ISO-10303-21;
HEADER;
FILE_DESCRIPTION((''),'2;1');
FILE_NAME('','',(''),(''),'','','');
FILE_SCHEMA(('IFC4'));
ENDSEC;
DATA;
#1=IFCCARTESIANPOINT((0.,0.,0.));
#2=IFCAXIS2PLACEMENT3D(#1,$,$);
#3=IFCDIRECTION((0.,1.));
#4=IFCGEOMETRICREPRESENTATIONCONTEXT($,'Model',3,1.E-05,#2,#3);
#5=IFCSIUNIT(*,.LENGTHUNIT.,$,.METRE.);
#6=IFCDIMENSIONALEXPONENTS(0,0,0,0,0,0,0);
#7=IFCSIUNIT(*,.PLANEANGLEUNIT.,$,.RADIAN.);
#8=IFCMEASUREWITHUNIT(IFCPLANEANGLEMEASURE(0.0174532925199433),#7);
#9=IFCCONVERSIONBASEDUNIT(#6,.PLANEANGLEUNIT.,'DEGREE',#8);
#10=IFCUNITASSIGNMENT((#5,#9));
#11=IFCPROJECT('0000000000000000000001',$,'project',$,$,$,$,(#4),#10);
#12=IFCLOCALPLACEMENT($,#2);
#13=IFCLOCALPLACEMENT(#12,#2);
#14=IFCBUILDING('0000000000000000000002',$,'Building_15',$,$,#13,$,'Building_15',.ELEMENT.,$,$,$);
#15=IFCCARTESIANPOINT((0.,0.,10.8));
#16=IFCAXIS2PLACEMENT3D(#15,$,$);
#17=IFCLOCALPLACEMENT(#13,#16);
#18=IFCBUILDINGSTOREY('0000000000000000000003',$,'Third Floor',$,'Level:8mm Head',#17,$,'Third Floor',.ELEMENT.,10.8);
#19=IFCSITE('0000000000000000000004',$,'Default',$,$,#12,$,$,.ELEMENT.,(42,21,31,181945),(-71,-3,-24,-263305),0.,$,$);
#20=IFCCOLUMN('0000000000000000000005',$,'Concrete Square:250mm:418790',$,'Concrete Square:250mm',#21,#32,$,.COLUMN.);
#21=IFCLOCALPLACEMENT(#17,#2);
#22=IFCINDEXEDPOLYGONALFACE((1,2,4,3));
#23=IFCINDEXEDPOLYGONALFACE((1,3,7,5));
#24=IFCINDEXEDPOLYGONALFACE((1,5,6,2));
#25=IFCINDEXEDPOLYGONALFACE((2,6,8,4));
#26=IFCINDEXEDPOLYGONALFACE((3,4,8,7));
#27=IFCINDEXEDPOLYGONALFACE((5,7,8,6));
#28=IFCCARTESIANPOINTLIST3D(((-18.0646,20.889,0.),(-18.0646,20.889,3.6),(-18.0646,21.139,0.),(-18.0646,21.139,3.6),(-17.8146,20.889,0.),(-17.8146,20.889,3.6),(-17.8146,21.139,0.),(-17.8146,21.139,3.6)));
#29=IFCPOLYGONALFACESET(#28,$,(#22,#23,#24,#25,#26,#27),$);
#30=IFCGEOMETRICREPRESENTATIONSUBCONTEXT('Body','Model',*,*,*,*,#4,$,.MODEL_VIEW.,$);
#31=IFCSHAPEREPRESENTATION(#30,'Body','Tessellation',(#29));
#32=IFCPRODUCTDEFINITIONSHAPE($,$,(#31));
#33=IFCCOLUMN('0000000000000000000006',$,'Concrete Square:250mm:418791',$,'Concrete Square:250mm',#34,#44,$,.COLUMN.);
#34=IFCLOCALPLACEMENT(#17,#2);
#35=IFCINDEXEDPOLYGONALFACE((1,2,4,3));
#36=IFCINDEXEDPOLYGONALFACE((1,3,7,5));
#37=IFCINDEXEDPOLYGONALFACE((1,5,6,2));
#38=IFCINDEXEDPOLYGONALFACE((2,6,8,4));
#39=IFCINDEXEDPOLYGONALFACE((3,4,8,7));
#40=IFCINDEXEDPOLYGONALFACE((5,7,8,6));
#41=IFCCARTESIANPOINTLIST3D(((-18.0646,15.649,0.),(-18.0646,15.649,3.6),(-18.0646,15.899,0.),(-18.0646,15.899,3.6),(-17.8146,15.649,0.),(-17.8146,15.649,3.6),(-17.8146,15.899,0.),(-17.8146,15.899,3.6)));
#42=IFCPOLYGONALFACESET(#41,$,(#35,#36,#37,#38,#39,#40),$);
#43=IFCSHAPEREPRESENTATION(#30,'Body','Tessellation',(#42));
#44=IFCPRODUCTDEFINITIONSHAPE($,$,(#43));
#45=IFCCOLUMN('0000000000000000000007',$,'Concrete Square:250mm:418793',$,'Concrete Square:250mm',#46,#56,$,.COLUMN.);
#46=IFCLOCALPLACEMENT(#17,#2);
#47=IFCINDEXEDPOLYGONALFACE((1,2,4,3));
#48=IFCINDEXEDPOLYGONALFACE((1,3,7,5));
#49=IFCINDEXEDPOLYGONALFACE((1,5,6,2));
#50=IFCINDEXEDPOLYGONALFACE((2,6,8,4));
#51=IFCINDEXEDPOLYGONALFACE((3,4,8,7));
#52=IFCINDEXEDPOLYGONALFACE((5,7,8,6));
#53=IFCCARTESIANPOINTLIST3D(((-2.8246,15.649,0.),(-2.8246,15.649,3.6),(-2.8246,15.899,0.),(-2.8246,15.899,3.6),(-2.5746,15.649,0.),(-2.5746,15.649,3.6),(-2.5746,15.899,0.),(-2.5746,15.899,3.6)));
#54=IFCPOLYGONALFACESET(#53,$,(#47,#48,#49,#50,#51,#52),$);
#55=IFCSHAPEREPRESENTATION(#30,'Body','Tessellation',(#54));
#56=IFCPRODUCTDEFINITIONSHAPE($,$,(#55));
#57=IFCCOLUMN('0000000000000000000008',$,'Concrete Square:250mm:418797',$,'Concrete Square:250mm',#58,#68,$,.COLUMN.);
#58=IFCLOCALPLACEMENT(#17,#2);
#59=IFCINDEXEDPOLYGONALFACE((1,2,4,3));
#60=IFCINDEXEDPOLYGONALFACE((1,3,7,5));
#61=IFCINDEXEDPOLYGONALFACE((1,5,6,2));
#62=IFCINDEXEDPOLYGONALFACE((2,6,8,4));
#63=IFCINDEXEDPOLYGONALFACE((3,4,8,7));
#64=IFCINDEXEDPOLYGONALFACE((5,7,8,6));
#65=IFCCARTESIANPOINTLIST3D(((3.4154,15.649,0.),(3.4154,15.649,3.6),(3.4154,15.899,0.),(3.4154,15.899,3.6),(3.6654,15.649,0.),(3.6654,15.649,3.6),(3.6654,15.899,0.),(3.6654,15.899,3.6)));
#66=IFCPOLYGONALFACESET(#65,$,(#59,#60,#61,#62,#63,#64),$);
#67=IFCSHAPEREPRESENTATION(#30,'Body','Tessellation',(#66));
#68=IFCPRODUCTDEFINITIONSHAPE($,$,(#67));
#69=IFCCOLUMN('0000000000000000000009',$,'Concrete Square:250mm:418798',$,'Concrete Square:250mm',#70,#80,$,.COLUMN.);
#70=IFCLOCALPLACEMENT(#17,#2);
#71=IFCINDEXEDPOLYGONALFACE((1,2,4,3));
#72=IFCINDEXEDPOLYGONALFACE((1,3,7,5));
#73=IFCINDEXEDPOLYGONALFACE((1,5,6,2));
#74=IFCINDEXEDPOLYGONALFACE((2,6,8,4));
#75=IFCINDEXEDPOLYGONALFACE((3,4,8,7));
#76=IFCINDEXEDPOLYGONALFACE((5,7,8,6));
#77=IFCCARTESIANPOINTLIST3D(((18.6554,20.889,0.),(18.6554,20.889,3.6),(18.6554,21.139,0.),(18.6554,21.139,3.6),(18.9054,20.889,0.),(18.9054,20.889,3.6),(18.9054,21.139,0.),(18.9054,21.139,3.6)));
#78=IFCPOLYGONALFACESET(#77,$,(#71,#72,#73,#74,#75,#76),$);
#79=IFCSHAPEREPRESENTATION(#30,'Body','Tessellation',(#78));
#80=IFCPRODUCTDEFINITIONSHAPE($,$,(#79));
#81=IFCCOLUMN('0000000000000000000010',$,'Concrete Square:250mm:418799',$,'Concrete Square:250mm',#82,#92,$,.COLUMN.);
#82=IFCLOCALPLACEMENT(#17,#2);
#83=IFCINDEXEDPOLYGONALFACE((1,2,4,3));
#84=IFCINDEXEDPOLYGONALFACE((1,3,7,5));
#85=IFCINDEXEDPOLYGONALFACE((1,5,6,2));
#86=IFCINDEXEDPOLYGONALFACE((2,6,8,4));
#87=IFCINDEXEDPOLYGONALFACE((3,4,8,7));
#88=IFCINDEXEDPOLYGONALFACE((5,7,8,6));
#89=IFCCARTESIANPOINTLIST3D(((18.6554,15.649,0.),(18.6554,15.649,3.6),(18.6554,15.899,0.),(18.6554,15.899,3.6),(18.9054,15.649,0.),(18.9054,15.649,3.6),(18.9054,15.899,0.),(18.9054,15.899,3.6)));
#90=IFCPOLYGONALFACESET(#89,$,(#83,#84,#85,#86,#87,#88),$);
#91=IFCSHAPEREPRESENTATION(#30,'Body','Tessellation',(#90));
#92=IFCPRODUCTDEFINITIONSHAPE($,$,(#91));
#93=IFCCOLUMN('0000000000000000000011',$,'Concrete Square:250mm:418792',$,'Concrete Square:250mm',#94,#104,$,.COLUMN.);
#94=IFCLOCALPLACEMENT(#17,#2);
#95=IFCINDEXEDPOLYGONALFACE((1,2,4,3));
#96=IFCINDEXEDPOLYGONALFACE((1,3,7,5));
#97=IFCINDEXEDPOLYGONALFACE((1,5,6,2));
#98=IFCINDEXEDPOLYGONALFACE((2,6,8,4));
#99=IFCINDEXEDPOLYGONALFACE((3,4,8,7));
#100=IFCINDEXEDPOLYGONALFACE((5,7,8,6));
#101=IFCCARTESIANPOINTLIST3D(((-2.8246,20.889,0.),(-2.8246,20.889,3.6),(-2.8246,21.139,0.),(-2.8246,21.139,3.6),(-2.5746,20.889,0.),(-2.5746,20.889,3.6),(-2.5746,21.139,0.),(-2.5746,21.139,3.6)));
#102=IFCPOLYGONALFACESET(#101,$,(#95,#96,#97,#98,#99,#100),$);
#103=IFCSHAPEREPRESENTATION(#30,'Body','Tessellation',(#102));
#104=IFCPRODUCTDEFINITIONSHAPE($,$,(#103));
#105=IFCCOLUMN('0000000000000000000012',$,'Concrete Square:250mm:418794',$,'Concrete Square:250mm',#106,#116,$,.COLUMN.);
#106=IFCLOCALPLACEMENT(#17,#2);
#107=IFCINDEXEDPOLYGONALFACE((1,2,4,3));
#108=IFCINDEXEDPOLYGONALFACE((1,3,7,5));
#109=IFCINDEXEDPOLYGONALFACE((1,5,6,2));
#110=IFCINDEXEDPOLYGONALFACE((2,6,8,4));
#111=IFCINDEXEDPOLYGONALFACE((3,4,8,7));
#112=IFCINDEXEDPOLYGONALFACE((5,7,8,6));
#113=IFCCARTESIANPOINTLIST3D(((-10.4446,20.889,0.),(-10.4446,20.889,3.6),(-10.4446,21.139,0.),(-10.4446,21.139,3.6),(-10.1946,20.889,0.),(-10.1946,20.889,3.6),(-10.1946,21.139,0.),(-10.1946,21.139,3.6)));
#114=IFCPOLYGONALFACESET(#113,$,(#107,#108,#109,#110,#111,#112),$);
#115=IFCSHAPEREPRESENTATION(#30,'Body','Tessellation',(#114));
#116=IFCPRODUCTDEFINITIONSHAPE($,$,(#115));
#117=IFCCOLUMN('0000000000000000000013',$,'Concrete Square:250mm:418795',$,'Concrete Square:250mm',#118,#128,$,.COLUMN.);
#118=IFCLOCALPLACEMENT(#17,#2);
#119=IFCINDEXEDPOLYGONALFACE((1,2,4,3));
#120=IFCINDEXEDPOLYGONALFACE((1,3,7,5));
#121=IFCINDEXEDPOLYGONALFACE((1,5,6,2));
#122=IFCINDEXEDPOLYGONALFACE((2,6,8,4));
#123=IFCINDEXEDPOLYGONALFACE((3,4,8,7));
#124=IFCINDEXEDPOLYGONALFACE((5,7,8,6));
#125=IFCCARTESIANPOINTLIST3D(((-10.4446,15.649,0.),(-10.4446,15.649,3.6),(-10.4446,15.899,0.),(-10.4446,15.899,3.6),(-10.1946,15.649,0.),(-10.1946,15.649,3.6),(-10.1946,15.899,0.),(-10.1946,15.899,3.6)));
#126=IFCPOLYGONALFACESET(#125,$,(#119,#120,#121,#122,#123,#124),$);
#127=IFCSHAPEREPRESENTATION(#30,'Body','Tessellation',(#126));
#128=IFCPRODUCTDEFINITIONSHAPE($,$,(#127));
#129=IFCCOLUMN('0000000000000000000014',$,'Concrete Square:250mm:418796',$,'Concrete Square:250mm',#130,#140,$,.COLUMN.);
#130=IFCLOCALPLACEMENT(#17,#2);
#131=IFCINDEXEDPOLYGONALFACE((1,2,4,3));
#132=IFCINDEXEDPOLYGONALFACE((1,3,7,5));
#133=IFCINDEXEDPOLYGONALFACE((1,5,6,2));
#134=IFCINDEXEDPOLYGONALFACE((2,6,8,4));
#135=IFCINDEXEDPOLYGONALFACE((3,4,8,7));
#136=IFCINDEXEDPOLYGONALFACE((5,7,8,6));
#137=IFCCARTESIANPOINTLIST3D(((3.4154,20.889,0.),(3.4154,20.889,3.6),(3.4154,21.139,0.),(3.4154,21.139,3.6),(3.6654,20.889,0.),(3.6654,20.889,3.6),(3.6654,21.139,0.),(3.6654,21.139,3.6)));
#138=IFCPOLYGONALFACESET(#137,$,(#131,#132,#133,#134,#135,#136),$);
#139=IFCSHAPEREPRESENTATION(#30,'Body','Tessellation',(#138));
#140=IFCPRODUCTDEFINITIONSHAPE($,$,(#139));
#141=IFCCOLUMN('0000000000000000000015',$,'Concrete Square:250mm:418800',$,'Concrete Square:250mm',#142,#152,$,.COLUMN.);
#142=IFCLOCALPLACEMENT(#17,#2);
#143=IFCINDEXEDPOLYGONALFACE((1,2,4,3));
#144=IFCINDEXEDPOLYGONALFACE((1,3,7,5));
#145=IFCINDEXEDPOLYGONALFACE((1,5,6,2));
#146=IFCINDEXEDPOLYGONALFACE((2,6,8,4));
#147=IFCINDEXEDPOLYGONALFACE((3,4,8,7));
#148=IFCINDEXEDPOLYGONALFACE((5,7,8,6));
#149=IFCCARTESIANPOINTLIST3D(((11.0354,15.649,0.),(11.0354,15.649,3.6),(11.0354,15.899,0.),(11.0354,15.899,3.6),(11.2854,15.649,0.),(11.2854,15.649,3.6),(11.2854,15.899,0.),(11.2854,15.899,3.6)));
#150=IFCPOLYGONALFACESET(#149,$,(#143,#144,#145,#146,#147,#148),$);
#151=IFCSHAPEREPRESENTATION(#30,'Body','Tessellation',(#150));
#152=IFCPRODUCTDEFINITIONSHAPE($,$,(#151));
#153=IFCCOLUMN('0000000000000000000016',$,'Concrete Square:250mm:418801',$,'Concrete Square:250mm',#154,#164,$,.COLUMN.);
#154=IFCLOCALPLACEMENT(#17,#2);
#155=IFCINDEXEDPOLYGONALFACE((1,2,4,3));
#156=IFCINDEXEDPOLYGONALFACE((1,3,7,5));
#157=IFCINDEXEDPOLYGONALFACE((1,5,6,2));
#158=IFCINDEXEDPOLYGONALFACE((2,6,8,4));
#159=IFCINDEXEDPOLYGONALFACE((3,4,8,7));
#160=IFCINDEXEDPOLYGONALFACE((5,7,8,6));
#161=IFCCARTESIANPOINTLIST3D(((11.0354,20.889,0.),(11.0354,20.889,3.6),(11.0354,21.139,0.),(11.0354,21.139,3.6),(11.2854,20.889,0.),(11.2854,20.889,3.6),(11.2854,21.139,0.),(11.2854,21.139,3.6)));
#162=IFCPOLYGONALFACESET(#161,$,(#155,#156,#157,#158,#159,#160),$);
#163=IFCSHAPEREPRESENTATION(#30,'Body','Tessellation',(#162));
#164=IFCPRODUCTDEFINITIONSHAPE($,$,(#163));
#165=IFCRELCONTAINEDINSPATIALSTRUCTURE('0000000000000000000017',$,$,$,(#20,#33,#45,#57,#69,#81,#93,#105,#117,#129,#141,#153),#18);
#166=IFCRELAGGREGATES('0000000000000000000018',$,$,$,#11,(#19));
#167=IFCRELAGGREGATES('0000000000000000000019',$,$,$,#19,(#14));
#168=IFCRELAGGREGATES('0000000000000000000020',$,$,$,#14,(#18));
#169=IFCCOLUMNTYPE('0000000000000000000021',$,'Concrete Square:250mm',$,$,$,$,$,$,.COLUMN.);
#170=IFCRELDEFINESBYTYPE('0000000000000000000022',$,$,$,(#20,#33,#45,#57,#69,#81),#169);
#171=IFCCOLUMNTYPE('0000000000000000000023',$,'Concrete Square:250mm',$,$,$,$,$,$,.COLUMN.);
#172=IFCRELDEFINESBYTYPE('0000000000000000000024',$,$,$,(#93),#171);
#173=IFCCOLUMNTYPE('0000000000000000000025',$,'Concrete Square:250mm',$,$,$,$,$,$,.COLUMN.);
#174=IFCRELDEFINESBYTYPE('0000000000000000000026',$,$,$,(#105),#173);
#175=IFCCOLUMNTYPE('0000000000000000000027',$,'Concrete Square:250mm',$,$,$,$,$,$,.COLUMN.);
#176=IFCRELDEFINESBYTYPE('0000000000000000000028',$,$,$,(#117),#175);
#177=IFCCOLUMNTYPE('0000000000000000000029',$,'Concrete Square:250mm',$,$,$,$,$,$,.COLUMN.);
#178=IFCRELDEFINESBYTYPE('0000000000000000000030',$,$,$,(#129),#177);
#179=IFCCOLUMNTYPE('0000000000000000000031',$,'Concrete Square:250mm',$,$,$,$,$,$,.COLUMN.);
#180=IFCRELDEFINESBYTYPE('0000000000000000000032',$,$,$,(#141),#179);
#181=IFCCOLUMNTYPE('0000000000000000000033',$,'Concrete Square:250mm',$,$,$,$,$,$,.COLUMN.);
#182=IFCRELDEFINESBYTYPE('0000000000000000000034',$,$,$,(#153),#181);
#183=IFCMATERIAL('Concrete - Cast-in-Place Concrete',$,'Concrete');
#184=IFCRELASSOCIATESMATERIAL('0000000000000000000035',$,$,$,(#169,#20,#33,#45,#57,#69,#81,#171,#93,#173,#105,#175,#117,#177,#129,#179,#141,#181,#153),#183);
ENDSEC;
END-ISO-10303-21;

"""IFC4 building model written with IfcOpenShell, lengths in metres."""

from ifc_helpers import new_model, entity, si_unit, converted_unit, direction, frame, origin, place, context, subcontext, project, spatial, indexed_curve, outline, extrude, source, transform, mapped, material, type_object, type_shapes, element, save


model = new_model("IFC4")

# Units and contexts
model_context = context("Model", 3, precision=1e-05, world=origin(), true_north=direction((0.0, 1.0)))
body_context = subcontext(model_context, "Body", "Model", "MODEL_VIEW")
ifc_project = project(units=[si_unit("LENGTHUNIT", "METRE"), converted_unit("PLANEANGLEUNIT", "DEGREE", entity("IfcPlaneAngleMeasure", 0.0174532925199433), si_unit("PLANEANGLEUNIT", "RADIAN"), dimensions=[0, 0, 0, 0, 0, 0, 0])], contexts=[model_context])

# Site, building, storey
site_placement = place(None, origin())
site = spatial("IfcSite", under=ifc_project, at=site_placement, Name="Default", CompositionType="ELEMENT", RefLatitude=(42, 21, 31, 181945), RefLongitude=(-71, -3, -24, -263305), RefElevation=0.0)
building_placement = place(site_placement, origin())
building = spatial("IfcBuilding", under=site, at=building_placement, Name="Building_15", LongName="Building_15", CompositionType="ELEMENT")
storey_placement = place(building_placement, frame((0.0, 0.0, 10.8)))
storey = spatial("IfcBuildingStorey", under=building, at=storey_placement, Name="Third Floor", ObjectType="Level:8mm Head", LongName="Third Floor", CompositionType="ELEMENT", Elevation=10.8)

# Columns
ifc_material_1 = material(Name="Concrete - Cast-in-Place Concrete", Category="Concrete")
column_type_1 = type_object("IfcColumnType", Name="Concrete Square:250mm", PredefinedType="COLUMN", material=ifc_material_1)
shared_shape_1 = source(origin(), body_context, "Body", "SweptSolid", [
    extrude(outline(indexed_curve([(-0.125, -0.125), (0.125, -0.125), (0.125, 0.125), (-0.125, 0.125), (-0.125, -0.125)], self_intersect=False)), frame((0.0, 0.0, 10.8), z_axis=(0.0, 0.0, 1.0), x_axis=(-1.0, 0.0, 0.0)), (0.0, 0.0, 1.0), 3.6),
])
type_shapes(column_type_1, [shared_shape_1])
for number, where, name in (
    (1, (-17.9396, 21.014, -10.8), "Concrete Square:250mm:418790"),
    (2, (-17.9396, 15.774, -10.8), "Concrete Square:250mm:418791"),
    (3, (-2.6996, 15.774, -10.8), "Concrete Square:250mm:418793"),
    (4, (3.5404, 15.774, -10.8), "Concrete Square:250mm:418797"),
    (5, (18.7804, 21.014, -10.8), "Concrete Square:250mm:418798"),
    (6, (18.7804, 15.774, -10.8), "Concrete Square:250mm:418799"),
):
    element("IfcColumn", number, at=place(storey_placement, frame(where)), inside=storey, type_object=column_type_1, material=ifc_material_1, Name=name, ObjectType="Concrete Square:250mm", PredefinedType="COLUMN", context=body_context, shape_type="MappedRepresentation", body=[
        mapped(shared_shape_1, transform((0.0, 0.0, 0.0), scale=1.0)),
    ])
column_type_2 = type_object("IfcColumnType", Name="Concrete Square:250mm", PredefinedType="COLUMN", material=ifc_material_1)
shared_shape_2 = source(origin(), body_context, "Body", "SweptSolid", [
    extrude(outline(indexed_curve([(-0.125, -0.125), (0.125, -0.125), (0.125, 0.125), (-0.125, 0.125), (-0.125, -0.125)], self_intersect=False)), frame((-2.6996, 21.014, 10.8), z_axis=(0.0, 0.0, 1.0), x_axis=(-1.0, 0.0, 0.0)), (0.0, 0.0, 1.0), 3.6),
])
type_shapes(column_type_2, [shared_shape_2])
column_1_placement = place(storey_placement, frame((0.0, 0.0, -10.8)))
element("IfcColumn", 7, at=column_1_placement, inside=storey, type_object=column_type_2, material=ifc_material_1, Name="Concrete Square:250mm:418792", ObjectType="Concrete Square:250mm", PredefinedType="COLUMN", context=body_context, shape_type="MappedRepresentation", body=[
    mapped(shared_shape_2, transform((0.0, 0.0, 0.0), scale=1.0)),
])
column_type_3 = type_object("IfcColumnType", Name="Concrete Square:250mm", PredefinedType="COLUMN", material=ifc_material_1)
shared_shape_3 = source(origin(), body_context, "Body", "SweptSolid", [
    extrude(outline(indexed_curve([(-0.125, -0.125), (0.125, -0.125), (0.125, 0.125), (-0.125, 0.125), (-0.125, -0.125)], self_intersect=False)), frame((-10.3196, 21.014, 10.8), z_axis=(0.0, 0.0, 1.0), x_axis=(-1.0, 0.0, 0.0)), (0.0, 0.0, 1.0), 3.6),
])
type_shapes(column_type_3, [shared_shape_3])
column_2_placement = place(storey_placement, frame((0.0, 0.0, -10.8)))
element("IfcColumn", 8, at=column_2_placement, inside=storey, type_object=column_type_3, material=ifc_material_1, Name="Concrete Square:250mm:418794", ObjectType="Concrete Square:250mm", PredefinedType="COLUMN", context=body_context, shape_type="MappedRepresentation", body=[
    mapped(shared_shape_3, transform((0.0, 0.0, 0.0), scale=1.0)),
])
column_type_4 = type_object("IfcColumnType", Name="Concrete Square:250mm", PredefinedType="COLUMN", material=ifc_material_1)
shared_shape_4 = source(origin(), body_context, "Body", "SweptSolid", [
    extrude(outline(indexed_curve([(-0.125, -0.125), (0.125, -0.125), (0.125, 0.125), (-0.125, 0.125), (-0.125, -0.125)], self_intersect=False)), frame((-10.3196, 15.774, 10.8), z_axis=(0.0, 0.0, 1.0), x_axis=(-1.0, 0.0, 0.0)), (0.0, 0.0, 1.0), 3.6),
])
type_shapes(column_type_4, [shared_shape_4])
column_3_placement = place(storey_placement, frame((0.0, 0.0, -10.8)))
element("IfcColumn", 9, at=column_3_placement, inside=storey, type_object=column_type_4, material=ifc_material_1, Name="Concrete Square:250mm:418795", ObjectType="Concrete Square:250mm", PredefinedType="COLUMN", context=body_context, shape_type="MappedRepresentation", body=[
    mapped(shared_shape_4, transform((0.0, 0.0, 0.0), scale=1.0)),
])
column_type_5 = type_object("IfcColumnType", Name="Concrete Square:250mm", PredefinedType="COLUMN", material=ifc_material_1)
shared_shape_5 = source(origin(), body_context, "Body", "SweptSolid", [
    extrude(outline(indexed_curve([(-0.125, -0.125), (0.125, -0.125), (0.125, 0.125), (-0.125, 0.125), (-0.125, -0.125)], self_intersect=False)), frame((3.5404, 21.014, 10.8), z_axis=(0.0, 0.0, 1.0), x_axis=(-1.0, 0.0, 0.0)), (0.0, 0.0, 1.0), 3.6),
])
type_shapes(column_type_5, [shared_shape_5])
column_4_placement = place(storey_placement, frame((0.0, 0.0, -10.8)))
element("IfcColumn", 10, at=column_4_placement, inside=storey, type_object=column_type_5, material=ifc_material_1, Name="Concrete Square:250mm:418796", ObjectType="Concrete Square:250mm", PredefinedType="COLUMN", context=body_context, shape_type="MappedRepresentation", body=[
    mapped(shared_shape_5, transform((0.0, 0.0, 0.0), scale=1.0)),
])
column_type_6 = type_object("IfcColumnType", Name="Concrete Square:250mm", PredefinedType="COLUMN", material=ifc_material_1)
shared_shape_6 = source(origin(), body_context, "Body", "SweptSolid", [
    extrude(outline(indexed_curve([(-0.125, -0.125), (0.125, -0.125), (0.125, 0.125), (-0.125, 0.125), (-0.125, -0.125)], self_intersect=False)), frame((11.1604, 15.774, 10.8), z_axis=(0.0, 0.0, 1.0), x_axis=(-1.0, 0.0, 0.0)), (0.0, 0.0, 1.0), 3.6),
])
type_shapes(column_type_6, [shared_shape_6])
column_5_placement = place(storey_placement, frame((0.0, 0.0, -10.8)))
element("IfcColumn", 11, at=column_5_placement, inside=storey, type_object=column_type_6, material=ifc_material_1, Name="Concrete Square:250mm:418800", ObjectType="Concrete Square:250mm", PredefinedType="COLUMN", context=body_context, shape_type="MappedRepresentation", body=[
    mapped(shared_shape_6, transform((0.0, 0.0, 0.0), scale=1.0)),
])
column_type_7 = type_object("IfcColumnType", Name="Concrete Square:250mm", PredefinedType="COLUMN", material=ifc_material_1)
shared_shape_7 = source(origin(), body_context, "Body", "SweptSolid", [
    extrude(outline(indexed_curve([(-0.125, -0.125), (0.125, -0.125), (0.125, 0.125), (-0.125, 0.125), (-0.125, -0.125)], self_intersect=False)), frame((11.1604, 21.014, 10.8), z_axis=(0.0, 0.0, 1.0), x_axis=(-1.0, 0.0, 0.0)), (0.0, 0.0, 1.0), 3.6),
])
type_shapes(column_type_7, [shared_shape_7])
column_6_placement = place(storey_placement, frame((0.0, 0.0, -10.8)))
element("IfcColumn", 12, at=column_6_placement, inside=storey, type_object=column_type_7, material=ifc_material_1, Name="Concrete Square:250mm:418801", ObjectType="Concrete Square:250mm", PredefinedType="COLUMN", context=body_context, shape_type="MappedRepresentation", body=[
    mapped(shared_shape_7, transform((0.0, 0.0, 0.0), scale=1.0)),
])

save(model, "model.ifc")
